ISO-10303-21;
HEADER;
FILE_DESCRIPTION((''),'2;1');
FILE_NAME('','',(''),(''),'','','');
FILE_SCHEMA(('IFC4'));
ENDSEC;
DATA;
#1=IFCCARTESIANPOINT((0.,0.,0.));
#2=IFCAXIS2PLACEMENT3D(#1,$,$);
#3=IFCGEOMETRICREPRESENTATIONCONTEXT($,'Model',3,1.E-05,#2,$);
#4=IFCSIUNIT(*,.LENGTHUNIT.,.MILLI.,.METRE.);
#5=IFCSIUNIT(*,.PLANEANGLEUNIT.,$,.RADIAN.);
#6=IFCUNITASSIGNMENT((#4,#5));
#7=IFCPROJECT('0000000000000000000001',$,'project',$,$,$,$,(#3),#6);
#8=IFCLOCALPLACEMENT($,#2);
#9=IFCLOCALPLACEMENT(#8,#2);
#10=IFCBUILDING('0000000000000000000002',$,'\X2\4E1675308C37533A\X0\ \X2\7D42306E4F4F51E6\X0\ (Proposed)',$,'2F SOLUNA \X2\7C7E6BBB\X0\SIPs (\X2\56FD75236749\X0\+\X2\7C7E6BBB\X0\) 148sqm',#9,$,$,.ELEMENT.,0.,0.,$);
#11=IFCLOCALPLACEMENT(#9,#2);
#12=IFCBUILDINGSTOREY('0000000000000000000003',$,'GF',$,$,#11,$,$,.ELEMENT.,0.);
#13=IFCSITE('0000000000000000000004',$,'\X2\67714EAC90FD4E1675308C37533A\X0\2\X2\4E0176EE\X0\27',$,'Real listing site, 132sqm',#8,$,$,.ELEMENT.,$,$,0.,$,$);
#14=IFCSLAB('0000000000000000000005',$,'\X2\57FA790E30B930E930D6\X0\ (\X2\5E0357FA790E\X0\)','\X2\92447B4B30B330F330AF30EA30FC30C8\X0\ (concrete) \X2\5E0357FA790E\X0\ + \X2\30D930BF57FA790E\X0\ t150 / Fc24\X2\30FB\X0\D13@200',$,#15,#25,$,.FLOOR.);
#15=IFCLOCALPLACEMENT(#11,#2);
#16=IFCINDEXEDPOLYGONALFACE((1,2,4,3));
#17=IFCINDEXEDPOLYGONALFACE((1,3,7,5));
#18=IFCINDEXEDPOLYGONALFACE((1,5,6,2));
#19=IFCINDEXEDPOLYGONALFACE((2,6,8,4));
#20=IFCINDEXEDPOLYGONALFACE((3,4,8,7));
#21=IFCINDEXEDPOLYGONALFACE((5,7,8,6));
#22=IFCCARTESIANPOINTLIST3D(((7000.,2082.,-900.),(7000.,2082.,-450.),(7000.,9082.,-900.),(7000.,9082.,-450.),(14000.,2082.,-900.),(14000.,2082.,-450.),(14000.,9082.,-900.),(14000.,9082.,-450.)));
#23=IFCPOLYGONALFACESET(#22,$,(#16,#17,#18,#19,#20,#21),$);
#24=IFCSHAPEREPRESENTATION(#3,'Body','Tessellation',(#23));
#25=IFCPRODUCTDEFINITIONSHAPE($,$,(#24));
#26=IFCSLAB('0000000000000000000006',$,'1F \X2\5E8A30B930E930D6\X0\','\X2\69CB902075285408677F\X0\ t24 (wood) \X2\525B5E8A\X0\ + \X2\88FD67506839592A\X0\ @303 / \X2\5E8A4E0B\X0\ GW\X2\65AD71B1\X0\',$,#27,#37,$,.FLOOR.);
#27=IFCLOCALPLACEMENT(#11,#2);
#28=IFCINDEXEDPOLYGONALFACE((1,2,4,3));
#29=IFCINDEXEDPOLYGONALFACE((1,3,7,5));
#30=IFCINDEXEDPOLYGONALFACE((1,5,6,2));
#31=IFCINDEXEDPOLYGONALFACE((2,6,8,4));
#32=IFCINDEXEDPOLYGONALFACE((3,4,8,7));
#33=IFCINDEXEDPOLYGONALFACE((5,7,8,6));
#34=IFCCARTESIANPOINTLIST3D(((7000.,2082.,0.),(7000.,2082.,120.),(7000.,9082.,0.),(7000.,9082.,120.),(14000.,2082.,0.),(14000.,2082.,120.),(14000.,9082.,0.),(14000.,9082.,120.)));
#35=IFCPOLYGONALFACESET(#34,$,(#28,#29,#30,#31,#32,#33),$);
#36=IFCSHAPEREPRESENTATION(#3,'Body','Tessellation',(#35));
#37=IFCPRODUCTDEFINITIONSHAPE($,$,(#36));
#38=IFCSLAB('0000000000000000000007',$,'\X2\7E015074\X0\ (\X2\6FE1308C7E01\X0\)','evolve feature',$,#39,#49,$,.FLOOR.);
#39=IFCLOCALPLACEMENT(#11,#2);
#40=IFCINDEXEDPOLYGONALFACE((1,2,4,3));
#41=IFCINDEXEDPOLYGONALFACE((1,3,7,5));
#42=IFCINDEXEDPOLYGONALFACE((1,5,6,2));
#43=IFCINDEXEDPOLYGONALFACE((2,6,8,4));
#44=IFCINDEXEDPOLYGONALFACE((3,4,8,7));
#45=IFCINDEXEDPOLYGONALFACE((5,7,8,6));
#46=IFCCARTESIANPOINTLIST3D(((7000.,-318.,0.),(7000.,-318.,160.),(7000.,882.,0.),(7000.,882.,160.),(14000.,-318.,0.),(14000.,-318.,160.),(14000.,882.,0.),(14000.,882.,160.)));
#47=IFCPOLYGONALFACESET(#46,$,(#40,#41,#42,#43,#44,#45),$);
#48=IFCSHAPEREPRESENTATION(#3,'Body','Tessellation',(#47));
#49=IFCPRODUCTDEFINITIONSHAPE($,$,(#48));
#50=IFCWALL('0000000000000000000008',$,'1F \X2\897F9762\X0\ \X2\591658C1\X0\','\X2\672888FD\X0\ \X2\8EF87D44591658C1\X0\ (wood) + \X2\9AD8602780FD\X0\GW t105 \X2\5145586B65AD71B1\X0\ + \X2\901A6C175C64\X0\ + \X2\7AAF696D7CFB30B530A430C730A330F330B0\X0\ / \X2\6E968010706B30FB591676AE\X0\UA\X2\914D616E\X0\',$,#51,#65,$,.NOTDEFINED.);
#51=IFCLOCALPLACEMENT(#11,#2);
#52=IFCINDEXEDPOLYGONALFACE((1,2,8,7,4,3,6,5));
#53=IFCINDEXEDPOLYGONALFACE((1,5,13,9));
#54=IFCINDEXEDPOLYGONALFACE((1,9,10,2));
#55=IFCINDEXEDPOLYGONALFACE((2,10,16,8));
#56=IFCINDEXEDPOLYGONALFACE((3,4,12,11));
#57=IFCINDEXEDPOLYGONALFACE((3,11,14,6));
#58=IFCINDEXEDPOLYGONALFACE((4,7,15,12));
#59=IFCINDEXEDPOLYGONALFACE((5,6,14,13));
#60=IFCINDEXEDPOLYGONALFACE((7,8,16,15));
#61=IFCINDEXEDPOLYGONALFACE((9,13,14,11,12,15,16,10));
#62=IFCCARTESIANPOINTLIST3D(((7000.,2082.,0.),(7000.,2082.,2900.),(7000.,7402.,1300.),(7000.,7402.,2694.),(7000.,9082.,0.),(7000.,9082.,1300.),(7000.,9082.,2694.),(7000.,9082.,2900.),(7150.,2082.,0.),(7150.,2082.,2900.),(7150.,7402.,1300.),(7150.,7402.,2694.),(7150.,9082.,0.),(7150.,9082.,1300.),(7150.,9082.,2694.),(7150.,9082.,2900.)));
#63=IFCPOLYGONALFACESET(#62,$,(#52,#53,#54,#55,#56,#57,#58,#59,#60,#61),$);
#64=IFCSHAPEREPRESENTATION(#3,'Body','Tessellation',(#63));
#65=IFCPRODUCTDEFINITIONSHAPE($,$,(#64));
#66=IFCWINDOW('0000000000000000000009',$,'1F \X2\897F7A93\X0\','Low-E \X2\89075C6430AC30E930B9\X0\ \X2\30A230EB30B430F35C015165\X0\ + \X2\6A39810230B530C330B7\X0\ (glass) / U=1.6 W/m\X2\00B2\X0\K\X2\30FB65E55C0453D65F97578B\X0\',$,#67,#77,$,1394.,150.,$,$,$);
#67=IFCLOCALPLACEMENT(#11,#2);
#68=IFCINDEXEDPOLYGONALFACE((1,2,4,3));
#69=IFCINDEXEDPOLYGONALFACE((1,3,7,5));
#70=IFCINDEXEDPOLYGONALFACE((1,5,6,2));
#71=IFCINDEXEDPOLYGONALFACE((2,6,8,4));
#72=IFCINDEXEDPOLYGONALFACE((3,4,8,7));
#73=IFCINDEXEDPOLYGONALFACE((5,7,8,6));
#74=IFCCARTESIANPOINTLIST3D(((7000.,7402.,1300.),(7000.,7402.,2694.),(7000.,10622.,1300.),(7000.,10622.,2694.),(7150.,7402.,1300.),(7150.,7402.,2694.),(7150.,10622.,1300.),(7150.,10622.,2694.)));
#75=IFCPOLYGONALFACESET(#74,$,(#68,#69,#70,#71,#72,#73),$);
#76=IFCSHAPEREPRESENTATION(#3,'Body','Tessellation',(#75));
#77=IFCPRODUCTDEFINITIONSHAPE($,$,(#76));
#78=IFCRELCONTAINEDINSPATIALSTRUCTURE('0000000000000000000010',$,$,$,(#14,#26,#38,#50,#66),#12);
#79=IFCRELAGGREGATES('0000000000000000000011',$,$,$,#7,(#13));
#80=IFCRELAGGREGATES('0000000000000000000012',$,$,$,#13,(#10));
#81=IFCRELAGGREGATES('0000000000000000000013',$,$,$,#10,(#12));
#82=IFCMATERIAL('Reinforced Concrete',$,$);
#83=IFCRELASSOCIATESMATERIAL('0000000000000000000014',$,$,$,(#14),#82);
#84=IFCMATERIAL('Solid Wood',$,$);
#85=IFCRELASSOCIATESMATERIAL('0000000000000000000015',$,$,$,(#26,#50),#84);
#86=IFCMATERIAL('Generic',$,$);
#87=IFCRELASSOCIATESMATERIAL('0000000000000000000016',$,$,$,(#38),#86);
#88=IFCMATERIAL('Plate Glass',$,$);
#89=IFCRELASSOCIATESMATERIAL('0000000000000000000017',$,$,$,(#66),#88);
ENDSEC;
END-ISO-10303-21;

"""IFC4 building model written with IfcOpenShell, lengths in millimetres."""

from ifc_helpers import new_model, si_unit, frame, frame_2d, origin, place, context, project, spatial, rectangle, extrude, material, element, fill, save


model = new_model("IFC4")

# Units and contexts
model_context = context("Model", 3, precision=1e-05, world=origin())
ifc_project = project(units=[si_unit("LENGTHUNIT", "METRE", prefix="MILLI"), si_unit("PLANEANGLEUNIT", "RADIAN")], contexts=[model_context])

# Site, building, storey
site_placement = place(None, origin())
site = spatial("IfcSite", under=ifc_project, at=site_placement, Name="東京都世田谷区2丁目27", ObjectType="Real listing site, 132sqm", CompositionType="ELEMENT", RefElevation=0.0)
building_placement = place(site_placement, origin())
building = spatial("IfcBuilding", under=site, at=building_placement, Name="世田谷区 終の住処 (Proposed)", ObjectType="2F SOLUNA 籾殻SIPs (国産杉+籾殻) 148sqm", CompositionType="ELEMENT", ElevationOfRefHeight=0.0, ElevationOfTerrain=0.0)
storey_placement = place(building_placement, origin())
storey = spatial("IfcBuildingStorey", under=building, at=storey_placement, Name="GF", CompositionType="ELEMENT", Elevation=0.0)

# Slabs
ifc_material_1 = material(Name="Reinforced Concrete")
slab_1_placement = place(storey_placement, frame((3500.0, 1041.0, -450.0)))
element("IfcSlab", 1, at=slab_1_placement, inside=storey, material=ifc_material_1, Name="基礎スラブ (布基礎)", Description="鉄筋コンクリート (concrete) 布基礎 + ベタ基礎 t150 / Fc24・D13@200", PredefinedType="FLOOR", context=model_context, shape_type="SweptSolid", body=[
    extrude(rectangle(XDim=7000.0, YDim=7000.0, at=frame_2d((3500.0, 3500.0))), frame((3500.0, 1041.0, -450.0)), (0.0, 0.0, 1.0), 450.0),
])
ifc_material_2 = material(Name="Solid Wood")
slab_2_placement = place(storey_placement, frame((3500.0, 1041.0, 0.0)))
element("IfcSlab", 2, at=slab_2_placement, inside=storey, material=ifc_material_2, Name="1F 床スラブ", Description="構造用合板 t24 (wood) 剛床 + 製材根太 @303 / 床下 GW断熱", PredefinedType="FLOOR", context=model_context, shape_type="SweptSolid", body=[
    extrude(rectangle(XDim=7000.0, YDim=7000.0, at=frame_2d((3500.0, 3500.0))), frame((3500.0, 1041.0, 0.0)), (0.0, 0.0, 1.0), 120.0),
])
ifc_material_3 = material(Name="Generic")
slab_3_placement = place(storey_placement, frame((3500.0, -159.0, 0.0)))
element("IfcSlab", 3, at=slab_3_placement, inside=storey, material=ifc_material_3, Name="縁側 (濡れ縁)", Description="evolve feature", PredefinedType="FLOOR", context=model_context, shape_type="SweptSolid", body=[
    extrude(rectangle(XDim=7000.0, YDim=1200.0, at=frame_2d((3500.0, 600.0))), frame((3500.0, -159.0, 0.0)), (0.0, 0.0, 1.0), 160.0),
])

# Shared definitions
ifc_material_4 = material(Name="Plate Glass")

# Wall, opening, window
wall_1_placement = place(storey_placement, frame((3500.0, 1041.0, 0.0)))
wall_1 = element("IfcWall", 4, at=wall_1_placement, inside=storey, material=ifc_material_2, Name="1F 西面 外壁", Description="木製 軸組外壁 (wood) + 高性能GW t105 充填断熱 + 通気層 + 窯業系サイディング / 準耐火・外皮UA配慮", PredefinedType="NOTDEFINED", context=model_context, shape_type="SweptSolid", body=[
    extrude(rectangle(XDim=150.0, YDim=7000.0, at=frame_2d((75.0, 3500.0))), frame((3500.0, 1041.0, 0.0)), (0.0, 0.0, 1.0), 2900.0),
])
opening_1_placement = place(storey_placement, frame((3500.0, 3701.0, 650.0)))
opening_1 = element("IfcOpeningElement", 5, at=opening_1_placement, cuts=wall_1, PredefinedType="NOTDEFINED", context=model_context, shape_type="SweptSolid", body=[
    extrude(rectangle(XDim=150.0, YDim=3220.0, at=frame_2d((75.0, 1610.0))), frame((3500.0, 3701.0, 650.0)), (0.0, 0.0, 1.0), 1394.0),
])
window_1_placement = place(storey_placement, frame((3500.0, 3701.0, 650.0)))
window_1 = element("IfcWindow", 6, at=window_1_placement, inside=storey, material=ifc_material_4, Name="1F 西窓", Description="Low-E 複層ガラス アルゴン封入 + 樹脂サッシ (glass) / U=1.6 W/m²K・日射取得型", OverallHeight=1394.0, OverallWidth=150.0, context=model_context, shape_type="SweptSolid", body=[
    extrude(rectangle(XDim=150.0, YDim=3220.0, at=frame_2d((75.0, 1610.0))), frame((3500.0, 3701.0, 650.0)), (0.0, 0.0, 1.0), 1394.0),
])
fill(opening_1, window_1)

save(model, "model.ifc")
